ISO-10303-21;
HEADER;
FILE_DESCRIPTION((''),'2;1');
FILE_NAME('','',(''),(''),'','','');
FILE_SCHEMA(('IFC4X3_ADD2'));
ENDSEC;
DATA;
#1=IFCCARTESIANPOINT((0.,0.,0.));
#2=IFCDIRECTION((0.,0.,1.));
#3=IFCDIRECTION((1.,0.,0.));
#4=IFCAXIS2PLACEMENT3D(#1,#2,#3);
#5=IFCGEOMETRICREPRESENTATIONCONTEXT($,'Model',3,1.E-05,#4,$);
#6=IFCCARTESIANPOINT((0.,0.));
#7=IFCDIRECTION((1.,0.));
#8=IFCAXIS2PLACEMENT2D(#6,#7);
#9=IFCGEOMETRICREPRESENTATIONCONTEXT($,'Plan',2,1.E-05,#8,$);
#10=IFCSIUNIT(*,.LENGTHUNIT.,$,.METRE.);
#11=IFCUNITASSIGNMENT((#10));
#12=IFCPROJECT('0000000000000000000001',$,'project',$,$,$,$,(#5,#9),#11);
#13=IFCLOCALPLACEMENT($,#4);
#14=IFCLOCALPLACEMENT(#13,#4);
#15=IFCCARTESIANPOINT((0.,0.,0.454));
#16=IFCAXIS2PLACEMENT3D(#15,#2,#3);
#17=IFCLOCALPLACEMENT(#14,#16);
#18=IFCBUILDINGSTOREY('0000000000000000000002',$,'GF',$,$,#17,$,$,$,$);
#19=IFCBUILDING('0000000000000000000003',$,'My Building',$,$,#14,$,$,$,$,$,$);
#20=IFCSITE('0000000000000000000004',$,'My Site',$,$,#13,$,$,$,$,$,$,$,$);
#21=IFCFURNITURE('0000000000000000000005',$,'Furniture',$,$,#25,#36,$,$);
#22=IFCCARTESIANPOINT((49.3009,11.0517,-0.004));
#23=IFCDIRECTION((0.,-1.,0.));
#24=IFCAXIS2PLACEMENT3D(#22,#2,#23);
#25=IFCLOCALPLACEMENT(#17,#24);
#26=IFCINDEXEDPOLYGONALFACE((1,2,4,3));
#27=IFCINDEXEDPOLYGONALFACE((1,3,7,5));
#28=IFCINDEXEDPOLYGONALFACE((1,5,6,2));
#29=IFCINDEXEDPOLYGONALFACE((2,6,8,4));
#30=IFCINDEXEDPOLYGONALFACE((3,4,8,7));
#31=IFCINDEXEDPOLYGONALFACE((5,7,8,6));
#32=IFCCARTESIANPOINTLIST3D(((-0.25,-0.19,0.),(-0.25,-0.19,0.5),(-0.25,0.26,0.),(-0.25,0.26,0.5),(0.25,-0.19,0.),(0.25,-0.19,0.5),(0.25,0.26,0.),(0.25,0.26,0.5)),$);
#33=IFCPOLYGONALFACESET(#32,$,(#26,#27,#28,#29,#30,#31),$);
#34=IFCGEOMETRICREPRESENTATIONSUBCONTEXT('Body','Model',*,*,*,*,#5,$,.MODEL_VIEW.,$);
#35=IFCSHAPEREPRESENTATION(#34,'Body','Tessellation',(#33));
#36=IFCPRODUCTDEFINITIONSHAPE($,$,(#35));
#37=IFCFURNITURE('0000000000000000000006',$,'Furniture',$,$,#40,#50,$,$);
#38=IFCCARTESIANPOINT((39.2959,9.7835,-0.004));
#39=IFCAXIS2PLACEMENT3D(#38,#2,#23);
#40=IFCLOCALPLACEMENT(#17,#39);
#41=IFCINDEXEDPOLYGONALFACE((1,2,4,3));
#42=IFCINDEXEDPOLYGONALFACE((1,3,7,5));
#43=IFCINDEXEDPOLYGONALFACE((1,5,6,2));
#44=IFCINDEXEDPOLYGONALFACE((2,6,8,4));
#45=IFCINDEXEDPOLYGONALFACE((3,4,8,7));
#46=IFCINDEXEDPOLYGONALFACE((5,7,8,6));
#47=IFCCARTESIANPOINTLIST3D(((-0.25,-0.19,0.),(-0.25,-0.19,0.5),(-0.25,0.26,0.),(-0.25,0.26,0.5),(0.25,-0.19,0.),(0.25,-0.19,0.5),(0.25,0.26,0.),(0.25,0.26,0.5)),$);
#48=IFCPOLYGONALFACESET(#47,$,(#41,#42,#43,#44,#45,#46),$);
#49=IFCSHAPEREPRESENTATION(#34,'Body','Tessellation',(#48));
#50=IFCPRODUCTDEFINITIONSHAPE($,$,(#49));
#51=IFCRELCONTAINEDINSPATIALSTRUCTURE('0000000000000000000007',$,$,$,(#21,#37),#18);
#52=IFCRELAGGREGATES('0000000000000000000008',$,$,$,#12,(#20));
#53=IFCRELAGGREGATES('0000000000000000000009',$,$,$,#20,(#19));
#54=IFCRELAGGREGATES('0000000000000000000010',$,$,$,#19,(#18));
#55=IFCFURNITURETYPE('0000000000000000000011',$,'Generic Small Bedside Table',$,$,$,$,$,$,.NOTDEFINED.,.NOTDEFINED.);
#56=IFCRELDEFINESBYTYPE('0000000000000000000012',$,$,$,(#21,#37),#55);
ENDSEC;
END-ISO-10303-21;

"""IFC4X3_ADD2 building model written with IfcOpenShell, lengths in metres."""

from ifc_helpers import new_model, entity, si_unit, frame, origin_with_axes, origin_2d_with_axis, place, context, subcontext, project, spatial, line, indexed_curve, outline, extrude, shape, source, transform, mapped, type_object, type_shapes, element, save


model = new_model("IFC4X3_ADD2")

# Units and contexts
model_context = context("Model", 3, precision=1e-05, world=origin_with_axes())
plan_context = context("Plan", 2, precision=1e-05, world=origin_2d_with_axis())
body_context_1 = subcontext(model_context, "Body", "Model", "MODEL_VIEW")
body_context_2 = subcontext(plan_context, "Body", "Plan", "PLAN_VIEW")
ifc_project = project(units=[si_unit("LENGTHUNIT", "METRE")], contexts=[model_context, plan_context])

# Site, building, storey
site_placement = place(None, origin_with_axes())
site = spatial("IfcSite", under=ifc_project, at=site_placement, Name="My Site")
building_placement = place(site_placement, origin_with_axes())
building = spatial("IfcBuilding", under=site, at=building_placement, Name="My Building")
storey_placement = place(building_placement, frame((0.0, 0.0, 0.454), z_axis=(0.0, 0.0, 1.0), x_axis=(1.0, 0.0, 0.0)))
storey = spatial("IfcBuildingStorey", under=building, at=storey_placement, Name="GF")

# Furniture
furniture_type_1 = type_object("IfcFurnitureType", Name="Generic Small Bedside Table", AssemblyPlace="NOTDEFINED", PredefinedType="NOTDEFINED")
shared_shape_1 = source(origin_with_axes(), body_context_1, "Body", "SweptSolid", [
    extrude(outline(indexed_curve([(0.5, 0.45), (0.5, 0.0), (0.0, 0.0), (0.0, 0.45)], segments=[line(4, 1), line(1, 2), line(2, 3), line(3, 4)], self_intersect=False)), frame((-0.25, -0.19, 0.0), z_axis=(0.0, 0.0, 1.0), x_axis=(1.0, 0.0, 0.0)), (0.0, 0.0, 1.0), 0.5),
])
shared_shape_2 = source(origin_with_axes(), body_context_2, "Body", "Annotation2D", [
    entity("IfcGeometricCurveSet", [entity("IfcIndexedPolyCurve", entity("IfcCartesianPointList2D", [[-0.25, -0.19], [0.25, -0.19], [0.25, 0.26], [-0.25, 0.26]]), [entity("IfcLineIndex", [1, 2]), entity("IfcLineIndex", [2, 3]), entity("IfcLineIndex", [3, 4]), entity("IfcLineIndex", [4, 1])])]),
])
type_shapes(furniture_type_1, [shared_shape_1, shared_shape_2])
for number, where, z_axis, x_axis, name in (
    (1, (49.3009, 11.0517, -0.004), (0.0, 0.0, 1.0), (0.0, -1.0, 0.0), "Furniture"),
    (2, (39.2959, 9.7835, -0.004), (0.0, 0.0, 1.0), (0.0, -1.0, 0.0), "Furniture"),
):
    element("IfcFurniture", number, at=place(storey_placement, frame(where, z_axis=z_axis, x_axis=x_axis)), inside=storey, type_object=furniture_type_1, Name=name, shapes=[
        shape(body_context_1, "Body", "MappedRepresentation", [mapped(shared_shape_1, transform((0.0, 0.0, 0.0), x_axis=(1.0, 0.0, 0.0), y_axis=(0.0, 1.0, 0.0), z_axis=(0.0, 0.0, 1.0), scale=1.0))]),
        shape(body_context_2, "Body", "MappedRepresentation", [mapped(shared_shape_2, transform((0.0, 0.0, 0.0), x_axis=(1.0, 0.0, 0.0), y_axis=(0.0, 1.0, 0.0), z_axis=(0.0, 0.0, 1.0), scale=1.0))]),
    ])

save(model, "model.ifc")
